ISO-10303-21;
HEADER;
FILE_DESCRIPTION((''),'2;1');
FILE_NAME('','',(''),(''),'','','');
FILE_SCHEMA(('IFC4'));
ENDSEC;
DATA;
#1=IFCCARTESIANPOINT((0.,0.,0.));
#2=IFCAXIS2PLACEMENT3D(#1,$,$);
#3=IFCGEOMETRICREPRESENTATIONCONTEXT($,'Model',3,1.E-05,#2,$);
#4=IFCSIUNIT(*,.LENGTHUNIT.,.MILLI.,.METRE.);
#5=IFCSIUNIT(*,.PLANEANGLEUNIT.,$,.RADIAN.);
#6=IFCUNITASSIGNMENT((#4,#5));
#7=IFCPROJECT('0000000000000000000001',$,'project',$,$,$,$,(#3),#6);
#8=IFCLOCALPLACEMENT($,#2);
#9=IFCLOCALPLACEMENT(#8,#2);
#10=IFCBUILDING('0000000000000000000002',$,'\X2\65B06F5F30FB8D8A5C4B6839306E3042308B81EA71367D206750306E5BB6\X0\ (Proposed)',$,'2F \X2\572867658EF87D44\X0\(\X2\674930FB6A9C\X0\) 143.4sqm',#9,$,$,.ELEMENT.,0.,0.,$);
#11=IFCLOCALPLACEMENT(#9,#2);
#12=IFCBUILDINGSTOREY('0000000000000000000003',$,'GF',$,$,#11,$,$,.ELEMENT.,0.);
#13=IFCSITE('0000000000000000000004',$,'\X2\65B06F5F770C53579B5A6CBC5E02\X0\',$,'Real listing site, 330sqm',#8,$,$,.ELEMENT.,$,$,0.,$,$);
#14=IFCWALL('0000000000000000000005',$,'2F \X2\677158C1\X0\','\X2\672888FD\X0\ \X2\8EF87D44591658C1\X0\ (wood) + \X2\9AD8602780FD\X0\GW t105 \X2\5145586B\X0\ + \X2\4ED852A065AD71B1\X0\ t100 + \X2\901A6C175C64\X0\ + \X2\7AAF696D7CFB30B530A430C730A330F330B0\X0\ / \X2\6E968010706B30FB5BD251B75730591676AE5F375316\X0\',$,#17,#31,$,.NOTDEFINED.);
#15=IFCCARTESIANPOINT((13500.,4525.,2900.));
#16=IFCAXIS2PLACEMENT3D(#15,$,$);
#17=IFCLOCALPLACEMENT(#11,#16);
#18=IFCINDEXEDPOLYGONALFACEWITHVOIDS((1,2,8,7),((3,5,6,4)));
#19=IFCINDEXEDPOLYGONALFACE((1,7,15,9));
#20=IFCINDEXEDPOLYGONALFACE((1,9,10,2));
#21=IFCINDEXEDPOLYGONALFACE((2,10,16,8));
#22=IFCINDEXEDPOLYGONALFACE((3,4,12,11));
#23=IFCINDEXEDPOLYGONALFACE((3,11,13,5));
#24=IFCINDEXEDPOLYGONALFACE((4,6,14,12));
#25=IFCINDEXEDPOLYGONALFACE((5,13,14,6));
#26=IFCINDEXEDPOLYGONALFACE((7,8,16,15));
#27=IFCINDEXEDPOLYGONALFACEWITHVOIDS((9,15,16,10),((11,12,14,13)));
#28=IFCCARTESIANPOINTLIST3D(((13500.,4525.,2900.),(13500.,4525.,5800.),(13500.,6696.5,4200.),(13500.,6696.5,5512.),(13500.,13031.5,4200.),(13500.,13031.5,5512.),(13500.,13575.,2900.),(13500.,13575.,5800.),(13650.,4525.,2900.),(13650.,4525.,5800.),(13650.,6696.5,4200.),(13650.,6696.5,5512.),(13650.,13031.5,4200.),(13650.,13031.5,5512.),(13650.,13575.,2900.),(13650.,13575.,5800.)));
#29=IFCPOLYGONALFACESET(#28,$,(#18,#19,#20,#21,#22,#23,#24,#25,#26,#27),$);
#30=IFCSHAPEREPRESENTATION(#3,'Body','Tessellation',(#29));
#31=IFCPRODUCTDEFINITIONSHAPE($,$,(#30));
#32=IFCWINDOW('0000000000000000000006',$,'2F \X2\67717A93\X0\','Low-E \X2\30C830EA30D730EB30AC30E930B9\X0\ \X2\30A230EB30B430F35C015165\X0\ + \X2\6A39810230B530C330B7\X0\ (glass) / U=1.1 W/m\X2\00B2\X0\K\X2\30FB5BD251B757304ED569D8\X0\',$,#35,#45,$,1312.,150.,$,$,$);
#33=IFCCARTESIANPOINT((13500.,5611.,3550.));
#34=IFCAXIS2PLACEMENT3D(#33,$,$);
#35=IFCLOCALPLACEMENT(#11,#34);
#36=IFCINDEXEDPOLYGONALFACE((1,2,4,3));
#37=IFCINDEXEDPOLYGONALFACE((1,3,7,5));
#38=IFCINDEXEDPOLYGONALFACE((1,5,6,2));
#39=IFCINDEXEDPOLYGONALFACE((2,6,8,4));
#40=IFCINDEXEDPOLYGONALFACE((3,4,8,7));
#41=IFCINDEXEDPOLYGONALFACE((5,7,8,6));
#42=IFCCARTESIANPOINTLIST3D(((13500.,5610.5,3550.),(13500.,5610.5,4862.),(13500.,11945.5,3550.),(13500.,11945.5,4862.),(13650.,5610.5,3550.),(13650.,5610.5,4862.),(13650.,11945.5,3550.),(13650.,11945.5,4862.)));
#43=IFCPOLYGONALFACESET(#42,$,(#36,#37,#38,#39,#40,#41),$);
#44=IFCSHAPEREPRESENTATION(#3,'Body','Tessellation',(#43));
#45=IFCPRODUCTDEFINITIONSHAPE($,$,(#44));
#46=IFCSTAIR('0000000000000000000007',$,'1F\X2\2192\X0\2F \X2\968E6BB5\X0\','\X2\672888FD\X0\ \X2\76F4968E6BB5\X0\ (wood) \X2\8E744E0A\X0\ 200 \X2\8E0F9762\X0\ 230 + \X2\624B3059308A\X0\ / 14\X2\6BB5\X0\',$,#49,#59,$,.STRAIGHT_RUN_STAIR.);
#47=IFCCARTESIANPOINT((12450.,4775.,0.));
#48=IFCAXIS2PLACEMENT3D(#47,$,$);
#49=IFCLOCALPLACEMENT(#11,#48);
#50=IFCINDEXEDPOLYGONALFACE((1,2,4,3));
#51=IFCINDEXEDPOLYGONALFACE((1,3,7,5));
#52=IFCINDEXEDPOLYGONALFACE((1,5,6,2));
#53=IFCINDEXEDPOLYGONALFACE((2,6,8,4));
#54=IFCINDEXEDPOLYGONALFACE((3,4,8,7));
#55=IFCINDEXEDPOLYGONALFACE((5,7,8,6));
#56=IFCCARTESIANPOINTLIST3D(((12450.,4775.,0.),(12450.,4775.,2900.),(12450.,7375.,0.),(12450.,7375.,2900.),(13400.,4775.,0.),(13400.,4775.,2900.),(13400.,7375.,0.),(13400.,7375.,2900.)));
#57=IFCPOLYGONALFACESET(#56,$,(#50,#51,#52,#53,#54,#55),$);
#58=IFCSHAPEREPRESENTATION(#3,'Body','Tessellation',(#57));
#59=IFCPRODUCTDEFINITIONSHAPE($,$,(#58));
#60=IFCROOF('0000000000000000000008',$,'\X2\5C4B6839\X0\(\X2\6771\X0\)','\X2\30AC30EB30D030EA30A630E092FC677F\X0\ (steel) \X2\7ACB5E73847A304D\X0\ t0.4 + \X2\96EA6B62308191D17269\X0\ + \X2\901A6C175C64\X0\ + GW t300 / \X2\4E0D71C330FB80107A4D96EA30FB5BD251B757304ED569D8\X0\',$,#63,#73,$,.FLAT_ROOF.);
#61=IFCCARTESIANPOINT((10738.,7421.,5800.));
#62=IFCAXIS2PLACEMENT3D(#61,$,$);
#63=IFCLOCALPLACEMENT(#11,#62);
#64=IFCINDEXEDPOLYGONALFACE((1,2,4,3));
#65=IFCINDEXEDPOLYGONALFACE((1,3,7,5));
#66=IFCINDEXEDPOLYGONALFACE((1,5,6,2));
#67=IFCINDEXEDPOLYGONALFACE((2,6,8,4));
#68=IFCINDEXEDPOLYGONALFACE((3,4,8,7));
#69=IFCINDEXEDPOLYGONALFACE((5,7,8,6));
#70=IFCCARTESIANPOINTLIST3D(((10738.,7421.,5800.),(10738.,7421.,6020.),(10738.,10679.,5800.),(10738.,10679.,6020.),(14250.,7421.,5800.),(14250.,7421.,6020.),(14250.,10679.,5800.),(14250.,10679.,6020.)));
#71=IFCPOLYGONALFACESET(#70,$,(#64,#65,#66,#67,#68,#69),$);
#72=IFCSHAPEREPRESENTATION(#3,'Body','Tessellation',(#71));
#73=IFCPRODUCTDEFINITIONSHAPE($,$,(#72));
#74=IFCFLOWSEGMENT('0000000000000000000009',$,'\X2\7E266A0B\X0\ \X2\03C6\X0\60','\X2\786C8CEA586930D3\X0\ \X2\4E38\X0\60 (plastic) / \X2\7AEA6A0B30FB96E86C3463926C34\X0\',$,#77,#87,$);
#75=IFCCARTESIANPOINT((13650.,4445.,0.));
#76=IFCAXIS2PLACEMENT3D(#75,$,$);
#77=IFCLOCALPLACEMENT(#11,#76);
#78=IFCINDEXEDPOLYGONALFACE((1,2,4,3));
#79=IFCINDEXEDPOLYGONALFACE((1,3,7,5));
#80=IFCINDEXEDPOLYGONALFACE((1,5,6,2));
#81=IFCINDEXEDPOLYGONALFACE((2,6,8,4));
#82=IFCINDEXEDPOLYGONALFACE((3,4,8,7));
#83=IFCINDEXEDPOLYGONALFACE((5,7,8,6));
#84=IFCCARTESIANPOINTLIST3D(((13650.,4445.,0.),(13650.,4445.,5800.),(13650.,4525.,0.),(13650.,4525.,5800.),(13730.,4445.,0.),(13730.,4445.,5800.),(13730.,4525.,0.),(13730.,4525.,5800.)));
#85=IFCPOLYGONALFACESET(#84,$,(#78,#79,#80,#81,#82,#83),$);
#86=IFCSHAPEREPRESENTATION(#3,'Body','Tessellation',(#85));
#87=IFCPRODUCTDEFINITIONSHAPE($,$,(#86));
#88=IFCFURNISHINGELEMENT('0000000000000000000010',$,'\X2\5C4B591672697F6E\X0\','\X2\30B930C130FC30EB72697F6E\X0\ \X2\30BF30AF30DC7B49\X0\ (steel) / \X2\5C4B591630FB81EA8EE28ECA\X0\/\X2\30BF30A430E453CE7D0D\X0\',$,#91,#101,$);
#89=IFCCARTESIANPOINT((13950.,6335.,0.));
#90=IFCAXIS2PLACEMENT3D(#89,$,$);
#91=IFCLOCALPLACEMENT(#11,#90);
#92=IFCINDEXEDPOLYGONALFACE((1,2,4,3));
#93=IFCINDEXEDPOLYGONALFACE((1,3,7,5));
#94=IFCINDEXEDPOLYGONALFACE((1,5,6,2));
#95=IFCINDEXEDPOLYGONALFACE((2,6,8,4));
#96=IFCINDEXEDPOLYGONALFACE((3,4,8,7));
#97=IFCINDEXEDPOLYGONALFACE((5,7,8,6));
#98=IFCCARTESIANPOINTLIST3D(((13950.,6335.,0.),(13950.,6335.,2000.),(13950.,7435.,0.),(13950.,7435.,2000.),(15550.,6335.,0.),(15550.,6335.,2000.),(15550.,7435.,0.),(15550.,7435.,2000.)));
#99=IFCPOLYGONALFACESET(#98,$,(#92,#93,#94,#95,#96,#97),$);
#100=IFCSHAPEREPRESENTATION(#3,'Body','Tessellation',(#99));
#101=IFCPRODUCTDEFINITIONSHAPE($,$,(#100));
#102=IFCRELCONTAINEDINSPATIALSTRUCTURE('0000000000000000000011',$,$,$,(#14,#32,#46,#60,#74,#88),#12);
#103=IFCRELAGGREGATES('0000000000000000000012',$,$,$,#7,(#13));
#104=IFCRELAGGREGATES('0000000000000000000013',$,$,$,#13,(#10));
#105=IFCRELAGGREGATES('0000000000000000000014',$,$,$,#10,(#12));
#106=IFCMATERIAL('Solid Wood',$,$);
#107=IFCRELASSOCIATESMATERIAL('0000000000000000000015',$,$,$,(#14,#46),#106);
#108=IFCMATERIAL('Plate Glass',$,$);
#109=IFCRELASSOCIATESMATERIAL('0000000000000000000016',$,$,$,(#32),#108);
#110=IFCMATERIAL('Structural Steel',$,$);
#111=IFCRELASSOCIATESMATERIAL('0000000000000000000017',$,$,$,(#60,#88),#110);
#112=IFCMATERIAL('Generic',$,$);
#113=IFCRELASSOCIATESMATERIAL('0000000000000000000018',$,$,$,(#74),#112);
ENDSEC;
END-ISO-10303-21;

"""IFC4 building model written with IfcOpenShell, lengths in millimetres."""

from ifc_helpers import new_model, si_unit, frame, frame_2d, origin, place, context, project, spatial, rectangle, extrude, material, element, fill, save


model = new_model("IFC4")

# Units and contexts
model_context = context("Model", 3, precision=1e-05, world=origin())
ifc_project = project(units=[si_unit("LENGTHUNIT", "METRE", prefix="MILLI"), si_unit("PLANEANGLEUNIT", "RADIAN")], contexts=[model_context])

# Site, building, storey
site_placement = place(None, origin())
site = spatial("IfcSite", under=ifc_project, at=site_placement, Name="新潟県南魚沼市", ObjectType="Real listing site, 330sqm", CompositionType="ELEMENT", RefElevation=0.0)
building_placement = place(site_placement, origin())
building = spatial("IfcBuilding", under=site, at=building_placement, Name="新潟・越屋根のある自然素材の家 (Proposed)", ObjectType="2F 在来軸組(杉・檜) 143.4sqm", CompositionType="ELEMENT", ElevationOfRefHeight=0.0, ElevationOfTerrain=0.0)
storey_placement = place(building_placement, origin())
storey = spatial("IfcBuildingStorey", under=building, at=storey_placement, Name="GF", CompositionType="ELEMENT", Elevation=0.0)

# Shared definitions
ifc_material_1 = material(Name="Solid Wood")

# Wall, opening, window
ifc_material_2 = material(Name="Plate Glass")
wall_1_placement = place(storey_placement, frame((13500.0, 4525.0, 2900.0)))
wall_1 = element("IfcWall", 1, at=wall_1_placement, inside=storey, material=ifc_material_1, Name="2F 東壁", Description="木製 軸組外壁 (wood) + 高性能GW t105 充填 + 付加断熱 t100 + 通気層 + 窯業系サイディング / 準耐火・寒冷地外皮強化", PredefinedType="NOTDEFINED", context=model_context, shape_type="SweptSolid", body=[
    extrude(rectangle(XDim=150.0, YDim=9050.0, at=frame_2d((75.0, 4525.0))), frame((13500.0, 4525.0, 2900.0)), (0.0, 0.0, 1.0), 2900.0),
])
opening_1_placement = place(storey_placement, frame((13500.0, 5611.0, 3550.0)))
opening_1 = element("IfcOpeningElement", 2, at=opening_1_placement, cuts=wall_1, PredefinedType="NOTDEFINED", context=model_context, shape_type="SweptSolid", body=[
    extrude(rectangle(XDim=150.0, YDim=6335.0, at=frame_2d((75.0, 3167.0))), frame((13500.0, 5611.0, 3550.0)), (0.0, 0.0, 1.0), 1312.0),
])
window_1_placement = place(storey_placement, frame((13500.0, 5611.0, 3550.0)))
window_1 = element("IfcWindow", 3, at=window_1_placement, inside=storey, material=ifc_material_2, Name="2F 東窓", Description="Low-E トリプルガラス アルゴン封入 + 樹脂サッシ (glass) / U=1.1 W/m²K・寒冷地仕様", OverallHeight=1312.0, OverallWidth=150.0, context=model_context, shape_type="SweptSolid", body=[
    extrude(rectangle(XDim=150.0, YDim=6335.0, at=frame_2d((75.0, 3167.0))), frame((13500.0, 5611.0, 3550.0)), (0.0, 0.0, 1.0), 1312.0),
])
fill(opening_1, window_1)

# Stair
stair_placement = place(storey_placement, frame((12450.0, 4775.0, 0.0)))
element("IfcStair", 4, at=stair_placement, inside=storey, material=ifc_material_1, Name="1F→2F 階段", Description="木製 直階段 (wood) 蹴上 200 踏面 230 + 手すり / 14段", PredefinedType="STRAIGHT_RUN_STAIR", context=model_context, shape_type="SweptSolid", body=[
    extrude(rectangle(XDim=950.0, YDim=2600.0, at=frame_2d((475.0, 1300.0))), frame((12450.0, 4775.0, 0.0)), (0.0, 0.0, 1.0), 2900.0),
])

# Roof
ifc_material_3 = material(Name="Structural Steel")
for number, where, name in (
    (5, (10738.0, 7421.0, 5800.0), "屋根(東)"),
):
    element("IfcRoof", number, at=place(storey_placement, frame(where)), inside=storey, material=ifc_material_3, Name=name, Description="ガルバリウム鋼板 (steel) 立平葺き t0.4 + 雪止め金物 + 通気層 + GW t300 / 不燃・耐積雪・寒冷地仕様", PredefinedType="FLAT_ROOF", context=model_context, shape_type="SweptSolid", body=[
        extrude(rectangle(XDim=3512.0, YDim=3258.0, at=frame_2d((1756.0, 1629.0))), frame((10738.0, 7421.0, 5800.0)), (0.0, 0.0, 1.0), 220.0),
    ])

# Flow segment
ifc_material_4 = material(Name="Generic")
flow_segment_placement = place(storey_placement, frame((13650.0, 4445.0, 0.0)))
element("IfcFlowSegment", 6, at=flow_segment_placement, inside=storey, material=ifc_material_4, Name="縦樋 φ60", Description="硬質塩ビ 丸60 (plastic) / 竪樋・雨水排水", context=model_context, shape_type="SweptSolid", body=[
    extrude(rectangle(XDim=80.0, YDim=80.0, at=frame_2d((40.0, 40.0))), frame((13650.0, 4445.0, 0.0)), (0.0, 0.0, 1.0), 5800.0),
])

# Furnishing element
furnishing_placement = place(storey_placement, frame((13950.0, 6335.0, 0.0)))
element("IfcFurnishingElement", 7, at=furnishing_placement, inside=storey, material=ifc_material_3, Name="屋外物置", Description="スチール物置 タクボ等 (steel) / 屋外・自転車/タイヤ収納", context=model_context, shape_type="SweptSolid", body=[
    extrude(rectangle(XDim=1600.0, YDim=1100.0, at=frame_2d((800.0, 550.0))), frame((13950.0, 6335.0, 0.0)), (0.0, 0.0, 1.0), 2000.0),
])

save(model, "model.ifc")
